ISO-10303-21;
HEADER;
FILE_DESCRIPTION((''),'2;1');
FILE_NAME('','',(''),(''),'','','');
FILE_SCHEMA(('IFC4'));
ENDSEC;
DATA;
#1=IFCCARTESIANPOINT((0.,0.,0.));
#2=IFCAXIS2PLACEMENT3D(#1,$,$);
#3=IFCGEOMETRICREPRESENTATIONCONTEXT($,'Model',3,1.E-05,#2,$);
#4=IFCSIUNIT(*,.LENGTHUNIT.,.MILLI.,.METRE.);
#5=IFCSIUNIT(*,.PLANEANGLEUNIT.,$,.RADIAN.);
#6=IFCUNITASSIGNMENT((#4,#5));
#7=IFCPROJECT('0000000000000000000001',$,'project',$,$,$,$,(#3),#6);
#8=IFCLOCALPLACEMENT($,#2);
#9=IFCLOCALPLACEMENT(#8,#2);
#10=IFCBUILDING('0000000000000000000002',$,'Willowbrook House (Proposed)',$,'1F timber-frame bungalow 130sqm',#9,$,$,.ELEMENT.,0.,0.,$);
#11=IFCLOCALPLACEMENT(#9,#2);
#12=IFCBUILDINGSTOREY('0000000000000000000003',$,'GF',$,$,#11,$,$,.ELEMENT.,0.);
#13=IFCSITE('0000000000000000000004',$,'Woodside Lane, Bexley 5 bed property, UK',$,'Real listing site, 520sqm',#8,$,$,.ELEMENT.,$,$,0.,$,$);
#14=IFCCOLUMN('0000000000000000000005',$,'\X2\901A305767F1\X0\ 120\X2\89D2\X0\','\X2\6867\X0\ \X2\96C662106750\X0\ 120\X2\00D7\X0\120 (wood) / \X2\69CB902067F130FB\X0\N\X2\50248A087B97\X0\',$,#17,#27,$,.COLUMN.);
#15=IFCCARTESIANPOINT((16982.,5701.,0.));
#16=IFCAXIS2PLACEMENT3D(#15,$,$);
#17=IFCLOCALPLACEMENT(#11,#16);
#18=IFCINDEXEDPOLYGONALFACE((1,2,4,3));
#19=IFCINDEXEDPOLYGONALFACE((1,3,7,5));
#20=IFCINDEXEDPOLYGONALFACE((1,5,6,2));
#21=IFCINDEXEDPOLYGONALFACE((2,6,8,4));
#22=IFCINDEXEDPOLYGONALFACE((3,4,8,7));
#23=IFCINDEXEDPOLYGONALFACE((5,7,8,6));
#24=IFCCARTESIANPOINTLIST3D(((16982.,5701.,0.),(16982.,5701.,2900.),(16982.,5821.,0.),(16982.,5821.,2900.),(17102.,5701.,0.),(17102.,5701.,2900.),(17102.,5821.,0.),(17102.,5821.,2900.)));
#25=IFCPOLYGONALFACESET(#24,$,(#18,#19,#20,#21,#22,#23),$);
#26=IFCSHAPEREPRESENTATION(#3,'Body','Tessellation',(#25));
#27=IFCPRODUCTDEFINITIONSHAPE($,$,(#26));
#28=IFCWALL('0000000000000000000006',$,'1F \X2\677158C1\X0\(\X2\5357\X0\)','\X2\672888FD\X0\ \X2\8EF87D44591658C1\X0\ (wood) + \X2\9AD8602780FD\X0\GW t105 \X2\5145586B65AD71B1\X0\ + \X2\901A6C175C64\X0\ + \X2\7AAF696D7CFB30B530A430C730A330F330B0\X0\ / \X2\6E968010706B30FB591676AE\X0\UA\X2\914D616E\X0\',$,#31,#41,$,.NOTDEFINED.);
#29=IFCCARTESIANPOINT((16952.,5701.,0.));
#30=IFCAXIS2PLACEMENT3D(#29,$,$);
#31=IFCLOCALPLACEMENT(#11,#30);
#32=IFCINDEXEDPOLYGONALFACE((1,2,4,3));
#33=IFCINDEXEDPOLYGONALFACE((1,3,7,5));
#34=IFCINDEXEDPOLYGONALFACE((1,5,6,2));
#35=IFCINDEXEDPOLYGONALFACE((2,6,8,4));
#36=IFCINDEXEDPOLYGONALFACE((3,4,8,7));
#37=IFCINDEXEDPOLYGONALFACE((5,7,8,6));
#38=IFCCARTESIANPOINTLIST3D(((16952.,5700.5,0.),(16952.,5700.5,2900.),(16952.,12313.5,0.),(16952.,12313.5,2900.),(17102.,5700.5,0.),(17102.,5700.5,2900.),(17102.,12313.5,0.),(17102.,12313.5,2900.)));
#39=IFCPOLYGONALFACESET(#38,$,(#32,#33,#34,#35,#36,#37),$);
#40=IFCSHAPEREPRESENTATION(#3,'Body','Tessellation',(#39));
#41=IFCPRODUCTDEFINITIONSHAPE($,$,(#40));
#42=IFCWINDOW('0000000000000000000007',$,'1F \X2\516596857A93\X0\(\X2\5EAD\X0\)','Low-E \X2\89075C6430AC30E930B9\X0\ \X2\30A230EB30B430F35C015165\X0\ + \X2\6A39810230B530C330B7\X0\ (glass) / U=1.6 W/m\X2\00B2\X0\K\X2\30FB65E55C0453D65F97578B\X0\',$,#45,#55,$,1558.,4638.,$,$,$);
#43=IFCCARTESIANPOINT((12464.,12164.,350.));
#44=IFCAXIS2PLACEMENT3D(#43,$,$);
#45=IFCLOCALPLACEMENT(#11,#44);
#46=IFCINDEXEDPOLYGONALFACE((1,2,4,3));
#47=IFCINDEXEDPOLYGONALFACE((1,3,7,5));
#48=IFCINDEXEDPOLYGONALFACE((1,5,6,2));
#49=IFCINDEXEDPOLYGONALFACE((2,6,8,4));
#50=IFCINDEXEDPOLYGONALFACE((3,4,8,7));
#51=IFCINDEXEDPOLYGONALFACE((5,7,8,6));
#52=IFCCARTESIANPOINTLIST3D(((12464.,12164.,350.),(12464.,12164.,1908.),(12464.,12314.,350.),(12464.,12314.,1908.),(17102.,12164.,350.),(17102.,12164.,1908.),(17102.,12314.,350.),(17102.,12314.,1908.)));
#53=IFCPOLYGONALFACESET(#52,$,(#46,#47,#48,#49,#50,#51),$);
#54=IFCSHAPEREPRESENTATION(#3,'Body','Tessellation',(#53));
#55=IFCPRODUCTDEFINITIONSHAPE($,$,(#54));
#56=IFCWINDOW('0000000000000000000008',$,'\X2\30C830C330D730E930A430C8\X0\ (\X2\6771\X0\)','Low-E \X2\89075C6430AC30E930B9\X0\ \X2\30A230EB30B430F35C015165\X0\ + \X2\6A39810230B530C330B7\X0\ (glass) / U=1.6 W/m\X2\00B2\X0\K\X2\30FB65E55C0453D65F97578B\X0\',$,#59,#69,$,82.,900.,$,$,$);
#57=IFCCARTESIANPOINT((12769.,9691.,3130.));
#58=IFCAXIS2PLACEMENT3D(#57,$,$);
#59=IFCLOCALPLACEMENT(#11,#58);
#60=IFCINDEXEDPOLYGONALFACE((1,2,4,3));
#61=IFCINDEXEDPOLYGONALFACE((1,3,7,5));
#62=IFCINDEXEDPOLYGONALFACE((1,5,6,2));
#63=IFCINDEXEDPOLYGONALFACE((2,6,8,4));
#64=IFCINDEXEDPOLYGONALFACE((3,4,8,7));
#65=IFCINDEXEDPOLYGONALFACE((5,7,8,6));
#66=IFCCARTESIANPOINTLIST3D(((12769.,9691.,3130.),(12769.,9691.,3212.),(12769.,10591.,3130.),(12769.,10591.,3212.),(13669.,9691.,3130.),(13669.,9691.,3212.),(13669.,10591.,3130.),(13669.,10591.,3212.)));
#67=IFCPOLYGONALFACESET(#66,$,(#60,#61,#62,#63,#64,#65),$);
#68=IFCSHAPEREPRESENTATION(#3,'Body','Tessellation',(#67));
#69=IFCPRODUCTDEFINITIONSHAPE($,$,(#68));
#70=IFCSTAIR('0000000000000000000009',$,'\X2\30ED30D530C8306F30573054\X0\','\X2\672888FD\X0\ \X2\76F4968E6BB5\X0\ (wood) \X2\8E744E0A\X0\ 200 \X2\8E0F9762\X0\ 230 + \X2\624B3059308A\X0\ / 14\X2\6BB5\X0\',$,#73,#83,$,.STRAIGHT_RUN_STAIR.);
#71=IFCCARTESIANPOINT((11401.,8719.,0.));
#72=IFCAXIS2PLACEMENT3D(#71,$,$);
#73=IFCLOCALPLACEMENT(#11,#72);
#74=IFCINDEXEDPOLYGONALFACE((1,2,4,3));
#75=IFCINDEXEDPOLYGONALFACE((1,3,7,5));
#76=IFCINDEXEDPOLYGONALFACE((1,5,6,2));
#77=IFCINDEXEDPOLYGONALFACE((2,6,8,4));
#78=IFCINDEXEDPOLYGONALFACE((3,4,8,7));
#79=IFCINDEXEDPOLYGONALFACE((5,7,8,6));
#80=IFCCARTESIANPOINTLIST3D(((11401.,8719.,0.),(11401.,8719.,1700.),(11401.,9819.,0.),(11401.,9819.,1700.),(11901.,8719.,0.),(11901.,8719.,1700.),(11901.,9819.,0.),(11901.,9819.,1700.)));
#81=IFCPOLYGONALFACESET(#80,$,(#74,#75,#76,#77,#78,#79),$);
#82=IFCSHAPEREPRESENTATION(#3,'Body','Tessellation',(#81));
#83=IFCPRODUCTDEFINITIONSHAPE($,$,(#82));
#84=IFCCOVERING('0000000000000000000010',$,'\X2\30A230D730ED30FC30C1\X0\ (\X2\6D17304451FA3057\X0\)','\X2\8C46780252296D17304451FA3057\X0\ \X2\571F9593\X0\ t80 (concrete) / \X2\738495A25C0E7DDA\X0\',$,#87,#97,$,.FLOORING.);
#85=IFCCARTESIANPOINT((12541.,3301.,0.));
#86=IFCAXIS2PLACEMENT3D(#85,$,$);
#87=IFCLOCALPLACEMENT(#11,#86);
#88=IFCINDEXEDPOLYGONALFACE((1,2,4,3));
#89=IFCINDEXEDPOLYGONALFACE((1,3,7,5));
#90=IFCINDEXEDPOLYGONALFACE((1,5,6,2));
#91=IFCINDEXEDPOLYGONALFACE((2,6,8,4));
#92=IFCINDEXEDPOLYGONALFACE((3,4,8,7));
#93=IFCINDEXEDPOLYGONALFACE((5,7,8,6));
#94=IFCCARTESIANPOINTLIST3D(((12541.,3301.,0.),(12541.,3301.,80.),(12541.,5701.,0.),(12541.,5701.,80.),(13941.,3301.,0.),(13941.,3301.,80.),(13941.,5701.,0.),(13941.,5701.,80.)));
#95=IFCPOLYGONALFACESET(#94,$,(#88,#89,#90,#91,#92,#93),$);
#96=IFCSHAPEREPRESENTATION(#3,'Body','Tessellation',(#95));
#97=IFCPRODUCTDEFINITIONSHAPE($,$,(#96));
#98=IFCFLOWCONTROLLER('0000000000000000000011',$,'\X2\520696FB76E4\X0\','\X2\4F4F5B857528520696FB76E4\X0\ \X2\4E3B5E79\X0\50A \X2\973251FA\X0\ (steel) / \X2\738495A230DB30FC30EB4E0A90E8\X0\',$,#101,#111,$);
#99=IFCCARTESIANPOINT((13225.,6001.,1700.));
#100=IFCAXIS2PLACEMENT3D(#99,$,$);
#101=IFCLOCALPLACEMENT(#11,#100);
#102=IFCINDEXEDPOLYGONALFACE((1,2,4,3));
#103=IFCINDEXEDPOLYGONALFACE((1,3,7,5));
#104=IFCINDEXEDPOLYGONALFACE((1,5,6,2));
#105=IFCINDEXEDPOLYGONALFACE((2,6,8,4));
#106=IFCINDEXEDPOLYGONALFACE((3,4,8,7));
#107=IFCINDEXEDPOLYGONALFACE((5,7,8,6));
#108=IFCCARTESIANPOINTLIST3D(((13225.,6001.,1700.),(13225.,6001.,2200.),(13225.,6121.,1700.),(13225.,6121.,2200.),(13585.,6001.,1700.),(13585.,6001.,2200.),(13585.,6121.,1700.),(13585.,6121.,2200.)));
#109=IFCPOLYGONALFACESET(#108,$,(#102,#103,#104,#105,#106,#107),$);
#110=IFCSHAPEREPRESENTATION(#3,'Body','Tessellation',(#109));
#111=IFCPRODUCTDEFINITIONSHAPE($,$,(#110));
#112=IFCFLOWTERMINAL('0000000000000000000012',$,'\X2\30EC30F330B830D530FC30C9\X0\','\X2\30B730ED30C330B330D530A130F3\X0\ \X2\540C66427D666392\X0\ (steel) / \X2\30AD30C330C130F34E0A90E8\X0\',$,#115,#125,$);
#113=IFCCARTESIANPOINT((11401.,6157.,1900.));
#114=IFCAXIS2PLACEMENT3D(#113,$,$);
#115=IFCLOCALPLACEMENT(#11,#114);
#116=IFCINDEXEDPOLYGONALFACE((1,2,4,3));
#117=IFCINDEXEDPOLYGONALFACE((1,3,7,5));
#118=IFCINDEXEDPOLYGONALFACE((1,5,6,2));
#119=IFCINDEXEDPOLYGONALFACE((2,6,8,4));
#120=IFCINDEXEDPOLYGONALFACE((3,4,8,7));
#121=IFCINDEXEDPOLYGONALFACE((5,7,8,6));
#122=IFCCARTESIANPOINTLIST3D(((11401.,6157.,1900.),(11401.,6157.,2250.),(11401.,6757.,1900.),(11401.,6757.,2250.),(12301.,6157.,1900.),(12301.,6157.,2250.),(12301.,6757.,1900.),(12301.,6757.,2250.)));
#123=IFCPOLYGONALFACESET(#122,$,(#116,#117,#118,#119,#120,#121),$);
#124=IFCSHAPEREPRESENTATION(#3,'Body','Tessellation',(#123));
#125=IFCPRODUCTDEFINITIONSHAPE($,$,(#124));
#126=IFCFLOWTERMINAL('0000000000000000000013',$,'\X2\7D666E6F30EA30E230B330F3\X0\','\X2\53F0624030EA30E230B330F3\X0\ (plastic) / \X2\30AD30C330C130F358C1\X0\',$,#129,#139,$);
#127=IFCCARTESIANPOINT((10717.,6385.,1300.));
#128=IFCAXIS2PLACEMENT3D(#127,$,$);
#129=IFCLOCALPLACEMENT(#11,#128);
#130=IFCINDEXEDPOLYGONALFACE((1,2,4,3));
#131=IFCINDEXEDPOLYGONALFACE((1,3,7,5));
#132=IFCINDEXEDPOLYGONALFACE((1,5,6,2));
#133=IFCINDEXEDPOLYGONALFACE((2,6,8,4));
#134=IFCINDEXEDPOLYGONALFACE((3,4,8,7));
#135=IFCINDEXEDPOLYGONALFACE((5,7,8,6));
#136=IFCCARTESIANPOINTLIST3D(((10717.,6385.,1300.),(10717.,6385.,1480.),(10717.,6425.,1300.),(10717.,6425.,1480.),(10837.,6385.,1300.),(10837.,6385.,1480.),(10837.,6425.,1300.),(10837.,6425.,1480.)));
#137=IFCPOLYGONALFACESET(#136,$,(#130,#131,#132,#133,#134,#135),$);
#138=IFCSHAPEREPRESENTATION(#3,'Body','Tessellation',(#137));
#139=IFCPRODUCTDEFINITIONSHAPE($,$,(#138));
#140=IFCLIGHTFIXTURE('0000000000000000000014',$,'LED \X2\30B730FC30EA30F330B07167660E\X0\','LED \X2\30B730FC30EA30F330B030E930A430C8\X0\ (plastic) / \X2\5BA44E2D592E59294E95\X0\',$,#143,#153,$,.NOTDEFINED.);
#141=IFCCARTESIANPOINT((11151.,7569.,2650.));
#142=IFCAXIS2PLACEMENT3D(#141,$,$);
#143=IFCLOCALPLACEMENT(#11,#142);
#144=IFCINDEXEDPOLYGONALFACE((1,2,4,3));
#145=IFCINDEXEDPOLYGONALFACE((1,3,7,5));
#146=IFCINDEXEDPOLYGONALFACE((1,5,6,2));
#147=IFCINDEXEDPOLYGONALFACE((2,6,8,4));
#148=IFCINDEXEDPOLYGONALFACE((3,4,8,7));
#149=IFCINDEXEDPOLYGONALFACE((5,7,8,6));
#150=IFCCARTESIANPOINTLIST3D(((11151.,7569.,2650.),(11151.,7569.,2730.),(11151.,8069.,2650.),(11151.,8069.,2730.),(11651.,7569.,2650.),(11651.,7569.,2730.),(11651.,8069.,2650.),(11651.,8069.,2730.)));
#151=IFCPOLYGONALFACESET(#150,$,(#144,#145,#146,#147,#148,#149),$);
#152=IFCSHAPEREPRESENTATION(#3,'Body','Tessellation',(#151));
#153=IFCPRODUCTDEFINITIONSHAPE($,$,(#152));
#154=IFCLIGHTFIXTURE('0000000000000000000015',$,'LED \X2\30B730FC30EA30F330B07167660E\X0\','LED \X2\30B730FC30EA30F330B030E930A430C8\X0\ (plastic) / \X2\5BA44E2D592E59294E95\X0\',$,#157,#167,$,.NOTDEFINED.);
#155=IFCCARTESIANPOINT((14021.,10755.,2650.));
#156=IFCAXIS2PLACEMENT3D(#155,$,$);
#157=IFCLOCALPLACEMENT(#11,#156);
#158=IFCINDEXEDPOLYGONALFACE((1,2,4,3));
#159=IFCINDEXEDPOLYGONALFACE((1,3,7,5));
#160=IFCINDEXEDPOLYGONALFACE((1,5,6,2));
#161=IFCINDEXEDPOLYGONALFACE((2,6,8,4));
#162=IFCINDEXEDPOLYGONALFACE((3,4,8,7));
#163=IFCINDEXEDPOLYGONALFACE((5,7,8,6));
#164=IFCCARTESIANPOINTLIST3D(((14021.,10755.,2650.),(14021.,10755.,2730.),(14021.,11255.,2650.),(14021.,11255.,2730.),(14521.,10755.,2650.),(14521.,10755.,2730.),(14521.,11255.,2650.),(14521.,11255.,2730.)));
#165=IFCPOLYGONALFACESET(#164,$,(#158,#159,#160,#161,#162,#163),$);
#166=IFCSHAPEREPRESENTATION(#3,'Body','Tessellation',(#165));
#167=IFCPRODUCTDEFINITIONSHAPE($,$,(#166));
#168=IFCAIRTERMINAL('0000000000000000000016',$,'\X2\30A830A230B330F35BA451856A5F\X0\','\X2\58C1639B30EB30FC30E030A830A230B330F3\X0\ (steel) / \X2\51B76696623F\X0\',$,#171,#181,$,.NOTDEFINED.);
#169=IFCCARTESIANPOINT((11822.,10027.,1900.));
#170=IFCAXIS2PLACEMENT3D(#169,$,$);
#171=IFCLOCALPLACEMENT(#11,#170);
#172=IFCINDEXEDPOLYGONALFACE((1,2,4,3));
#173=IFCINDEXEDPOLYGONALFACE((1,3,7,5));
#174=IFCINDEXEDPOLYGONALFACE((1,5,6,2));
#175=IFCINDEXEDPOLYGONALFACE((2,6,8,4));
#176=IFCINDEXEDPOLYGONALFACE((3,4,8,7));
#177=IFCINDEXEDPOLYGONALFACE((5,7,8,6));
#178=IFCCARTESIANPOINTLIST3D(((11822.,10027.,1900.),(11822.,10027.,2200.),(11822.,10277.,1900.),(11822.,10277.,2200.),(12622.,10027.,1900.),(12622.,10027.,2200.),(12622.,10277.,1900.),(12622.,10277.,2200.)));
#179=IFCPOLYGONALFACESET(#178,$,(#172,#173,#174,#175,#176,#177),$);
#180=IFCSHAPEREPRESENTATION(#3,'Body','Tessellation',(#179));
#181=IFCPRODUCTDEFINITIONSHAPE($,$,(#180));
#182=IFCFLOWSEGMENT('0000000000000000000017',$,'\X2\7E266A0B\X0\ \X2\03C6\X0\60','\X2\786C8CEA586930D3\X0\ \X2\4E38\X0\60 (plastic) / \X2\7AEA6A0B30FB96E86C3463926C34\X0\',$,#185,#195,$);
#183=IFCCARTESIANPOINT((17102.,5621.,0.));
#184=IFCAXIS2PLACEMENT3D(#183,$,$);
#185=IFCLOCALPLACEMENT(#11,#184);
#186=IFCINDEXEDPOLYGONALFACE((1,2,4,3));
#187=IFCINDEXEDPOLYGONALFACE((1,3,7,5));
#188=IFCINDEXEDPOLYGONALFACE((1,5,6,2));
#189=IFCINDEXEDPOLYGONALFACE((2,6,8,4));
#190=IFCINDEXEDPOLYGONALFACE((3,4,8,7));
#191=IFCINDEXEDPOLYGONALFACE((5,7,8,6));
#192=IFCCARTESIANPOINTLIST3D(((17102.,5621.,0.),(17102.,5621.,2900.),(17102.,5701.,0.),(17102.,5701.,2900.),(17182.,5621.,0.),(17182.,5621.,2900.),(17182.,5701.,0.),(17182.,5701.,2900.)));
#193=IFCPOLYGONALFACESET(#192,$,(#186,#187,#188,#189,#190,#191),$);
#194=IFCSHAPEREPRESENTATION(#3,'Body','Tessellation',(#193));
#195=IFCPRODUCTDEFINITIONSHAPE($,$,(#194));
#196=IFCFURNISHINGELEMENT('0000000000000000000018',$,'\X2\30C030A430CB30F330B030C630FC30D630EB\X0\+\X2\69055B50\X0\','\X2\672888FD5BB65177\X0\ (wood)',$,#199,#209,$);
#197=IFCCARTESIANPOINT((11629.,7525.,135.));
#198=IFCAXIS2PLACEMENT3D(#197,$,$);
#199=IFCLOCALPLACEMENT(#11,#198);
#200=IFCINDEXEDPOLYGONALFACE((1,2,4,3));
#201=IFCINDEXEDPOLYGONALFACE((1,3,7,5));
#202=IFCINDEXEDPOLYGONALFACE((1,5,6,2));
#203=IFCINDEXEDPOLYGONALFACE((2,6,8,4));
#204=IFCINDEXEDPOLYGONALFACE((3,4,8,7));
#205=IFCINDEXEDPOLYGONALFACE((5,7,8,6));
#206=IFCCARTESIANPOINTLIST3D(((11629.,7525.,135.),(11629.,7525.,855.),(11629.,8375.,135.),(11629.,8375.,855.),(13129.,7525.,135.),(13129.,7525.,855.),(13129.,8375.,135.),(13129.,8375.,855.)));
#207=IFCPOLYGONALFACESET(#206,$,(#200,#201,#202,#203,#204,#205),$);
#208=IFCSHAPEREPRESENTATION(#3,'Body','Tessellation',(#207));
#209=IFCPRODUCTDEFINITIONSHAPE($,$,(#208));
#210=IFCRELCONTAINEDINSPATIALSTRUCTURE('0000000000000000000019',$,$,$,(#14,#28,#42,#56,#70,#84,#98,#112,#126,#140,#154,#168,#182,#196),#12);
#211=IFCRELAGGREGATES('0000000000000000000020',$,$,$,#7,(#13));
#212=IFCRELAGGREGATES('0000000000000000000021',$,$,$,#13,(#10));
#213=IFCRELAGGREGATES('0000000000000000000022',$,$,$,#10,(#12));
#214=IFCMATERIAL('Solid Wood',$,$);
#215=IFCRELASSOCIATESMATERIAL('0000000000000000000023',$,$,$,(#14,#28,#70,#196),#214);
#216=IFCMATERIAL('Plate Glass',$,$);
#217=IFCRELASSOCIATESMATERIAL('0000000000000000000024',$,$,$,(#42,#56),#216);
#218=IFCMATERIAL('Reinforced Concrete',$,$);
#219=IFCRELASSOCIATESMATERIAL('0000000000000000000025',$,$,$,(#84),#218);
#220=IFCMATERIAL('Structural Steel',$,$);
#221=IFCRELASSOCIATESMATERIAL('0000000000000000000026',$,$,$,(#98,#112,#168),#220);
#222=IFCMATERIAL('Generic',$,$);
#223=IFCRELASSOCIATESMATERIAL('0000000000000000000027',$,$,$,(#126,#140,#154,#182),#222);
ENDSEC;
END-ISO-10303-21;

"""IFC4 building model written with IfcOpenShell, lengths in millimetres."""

from ifc_helpers import new_model, si_unit, frame, frame_2d, origin, place, context, project, spatial, rectangle, extrude, material, element, fill, save


model = new_model("IFC4")

# Units and contexts
model_context = context("Model", 3, precision=1e-05, world=origin())
ifc_project = project(units=[si_unit("LENGTHUNIT", "METRE", prefix="MILLI"), si_unit("PLANEANGLEUNIT", "RADIAN")], contexts=[model_context])

# Site, building, storey
site_placement = place(None, origin())
site = spatial("IfcSite", under=ifc_project, at=site_placement, Name="Woodside Lane, Bexley 5 bed property, UK", ObjectType="Real listing site, 520sqm", CompositionType="ELEMENT", RefElevation=0.0)
building_placement = place(site_placement, origin())
building = spatial("IfcBuilding", under=site, at=building_placement, Name="Willowbrook House (Proposed)", ObjectType="1F timber-frame bungalow 130sqm", CompositionType="ELEMENT", ElevationOfRefHeight=0.0, ElevationOfTerrain=0.0)
storey_placement = place(building_placement, origin())
storey = spatial("IfcBuildingStorey", under=building, at=storey_placement, Name="GF", CompositionType="ELEMENT", Elevation=0.0)

# Column
ifc_material_1 = material(Name="Solid Wood")
column_1_placement = place(storey_placement, frame((16982.0, 5701.0, 0.0)))
element("IfcColumn", 1, at=column_1_placement, inside=storey, material=ifc_material_1, Name="通し柱 120角", Description="桧 集成材 120×120 (wood) / 構造柱・N値計算", PredefinedType="COLUMN", context=model_context, shape_type="SweptSolid", body=[
    extrude(rectangle(XDim=120.0, YDim=120.0, at=frame_2d((60.0, 60.0))), frame((16982.0, 5701.0, 0.0)), (0.0, 0.0, 1.0), 2900.0),
])

# Wall, opening, window
wall_1_placement = place(storey_placement, frame((16952.0, 5701.0, 0.0)))
wall_1 = element("IfcWall", 2, at=wall_1_placement, inside=storey, material=ifc_material_1, Name="1F 東壁(南)", Description="木製 軸組外壁 (wood) + 高性能GW t105 充填断熱 + 通気層 + 窯業系サイディング / 準耐火・外皮UA配慮", PredefinedType="NOTDEFINED", context=model_context, shape_type="SweptSolid", body=[
    extrude(rectangle(XDim=150.0, YDim=6613.0, at=frame_2d((75.0, 3306.0))), frame((16952.0, 5701.0, 0.0)), (0.0, 0.0, 1.0), 2900.0),
])
opening_1_placement = place(storey_placement, frame((12464.0, 12164.0, 350.0)))
opening_1 = element("IfcOpeningElement", 3, at=opening_1_placement, cuts=wall_1, PredefinedType="NOTDEFINED", context=model_context, shape_type="SweptSolid", body=[
    extrude(rectangle(XDim=4638.0, YDim=150.0, at=frame_2d((2319.0, 75.0))), frame((12464.0, 12164.0, 350.0)), (0.0, 0.0, 1.0), 1558.0),
])
ifc_material_2 = material(Name="Plate Glass")
window_1_placement = place(storey_placement, frame((12464.0, 12164.0, 350.0)))
window_1 = element("IfcWindow", 4, at=window_1_placement, inside=storey, material=ifc_material_2, Name="1F 入隅窓(庭)", Description="Low-E 複層ガラス アルゴン封入 + 樹脂サッシ (glass) / U=1.6 W/m²K・日射取得型", OverallHeight=1558.0, OverallWidth=4638.0, context=model_context, shape_type="SweptSolid", body=[
    extrude(rectangle(XDim=4638.0, YDim=150.0, at=frame_2d((2319.0, 75.0))), frame((12464.0, 12164.0, 350.0)), (0.0, 0.0, 1.0), 1558.0),
])
fill(opening_1, window_1)

# Window
window_2_placement = place(storey_placement, frame((12769.0, 9691.0, 3130.0)))
element("IfcWindow", 5, at=window_2_placement, inside=storey, material=ifc_material_2, Name="トップライト (東)", Description="Low-E 複層ガラス アルゴン封入 + 樹脂サッシ (glass) / U=1.6 W/m²K・日射取得型", OverallHeight=82.0, OverallWidth=900.0, context=model_context, shape_type="SweptSolid", body=[
    extrude(rectangle(XDim=900.0, YDim=900.0, at=frame_2d((450.0, 450.0))), frame((12769.0, 9691.0, 3130.0)), (0.0, 0.0, 1.0), 82.0),
])

# Stair
stair_placement = place(storey_placement, frame((11401.0, 8719.0, 0.0)))
element("IfcStair", 6, at=stair_placement, inside=storey, material=ifc_material_1, Name="ロフトはしご", Description="木製 直階段 (wood) 蹴上 200 踏面 230 + 手すり / 14段", PredefinedType="STRAIGHT_RUN_STAIR", context=model_context, shape_type="SweptSolid", body=[
    extrude(rectangle(XDim=500.0, YDim=1100.0, at=frame_2d((250.0, 550.0))), frame((11401.0, 8719.0, 0.0)), (0.0, 0.0, 1.0), 1700.0),
])

# Covering
ifc_material_3 = material(Name="Reinforced Concrete")
covering_placement = place(storey_placement, frame((12541.0, 3301.0, 0.0)))
element("IfcCovering", 7, at=covering_placement, inside=storey, material=ifc_material_3, Name="アプローチ (洗い出し)", Description="豆砂利洗い出し 土間 t80 (concrete) / 玄関導線", PredefinedType="FLOORING", context=model_context, shape_type="SweptSolid", body=[
    extrude(rectangle(XDim=1400.0, YDim=2400.0, at=frame_2d((700.0, 1200.0))), frame((12541.0, 3301.0, 0.0)), (0.0, 0.0, 1.0), 80.0),
])

# Flow controller
ifc_material_4 = material(Name="Structural Steel")
flow_controller_placement = place(storey_placement, frame((13225.0, 6001.0, 1700.0)))
element("IfcFlowController", 8, at=flow_controller_placement, inside=storey, material=ifc_material_4, Name="分電盤", Description="住宅用分電盤 主幹50A 露出 (steel) / 玄関ホール上部", context=model_context, shape_type="SweptSolid", body=[
    extrude(rectangle(XDim=360.0, YDim=120.0, at=frame_2d((180.0, 60.0))), frame((13225.0, 6001.0, 1700.0)), (0.0, 0.0, 1.0), 500.0),
])

# Flow terminals
flow_terminal_1_placement = place(storey_placement, frame((11401.0, 6157.0, 1900.0)))
element("IfcFlowTerminal", 9, at=flow_terminal_1_placement, inside=storey, material=ifc_material_4, Name="レンジフード", Description="シロッコファン 同時給排 (steel) / キッチン上部", context=model_context, shape_type="SweptSolid", body=[
    extrude(rectangle(XDim=900.0, YDim=600.0, at=frame_2d((450.0, 300.0))), frame((11401.0, 6157.0, 1900.0)), (0.0, 0.0, 1.0), 350.0),
])
ifc_material_5 = material(Name="Generic")
flow_terminal_2_placement = place(storey_placement, frame((10717.0, 6385.0, 1300.0)))
element("IfcFlowTerminal", 10, at=flow_terminal_2_placement, inside=storey, material=ifc_material_5, Name="給湯リモコン", Description="台所リモコン (plastic) / キッチン壁", context=model_context, shape_type="SweptSolid", body=[
    extrude(rectangle(XDim=120.0, YDim=40.0, at=frame_2d((60.0, 20.0))), frame((10717.0, 6385.0, 1300.0)), (0.0, 0.0, 1.0), 180.0),
])

# Light fixtures
light_fixture_1_placement = place(storey_placement, frame((11151.0, 7569.0, 2650.0)))
element("IfcLightFixture", 11, at=light_fixture_1_placement, inside=storey, material=ifc_material_5, Name="LED シーリング照明", Description="LED シーリングライト (plastic) / 室中央天井", PredefinedType="NOTDEFINED", context=model_context, shape_type="SweptSolid", body=[
    extrude(rectangle(XDim=500.0, YDim=500.0, at=frame_2d((250.0, 250.0))), frame((11151.0, 7569.0, 2650.0)), (0.0, 0.0, 1.0), 80.0),
])
light_fixture_2_placement = place(storey_placement, frame((14021.0, 10755.0, 2650.0)))
element("IfcLightFixture", 12, at=light_fixture_2_placement, inside=storey, material=ifc_material_5, Name="LED シーリング照明", Description="LED シーリングライト (plastic) / 室中央天井", PredefinedType="NOTDEFINED", context=model_context, shape_type="SweptSolid", body=[
    extrude(rectangle(XDim=500.0, YDim=500.0, at=frame_2d((250.0, 250.0))), frame((14021.0, 10755.0, 2650.0)), (0.0, 0.0, 1.0), 80.0),
])

# Air terminal
air_terminal_placement = place(storey_placement, frame((11822.0, 10027.0, 1900.0)))
element("IfcAirTerminal", 13, at=air_terminal_placement, inside=storey, material=ifc_material_4, Name="エアコン室内機", Description="壁掛ルームエアコン (steel) / 冷暖房", PredefinedType="NOTDEFINED", context=model_context, shape_type="SweptSolid", body=[
    extrude(rectangle(XDim=800.0, YDim=250.0, at=frame_2d((400.0, 125.0))), frame((11822.0, 10027.0, 1900.0)), (0.0, 0.0, 1.0), 300.0),
])

# Flow segment
flow_segment_placement = place(storey_placement, frame((17102.0, 5621.0, 0.0)))
element("IfcFlowSegment", 14, at=flow_segment_placement, inside=storey, material=ifc_material_5, Name="縦樋 φ60", Description="硬質塩ビ 丸60 (plastic) / 竪樋・雨水排水", context=model_context, shape_type="SweptSolid", body=[
    extrude(rectangle(XDim=80.0, YDim=80.0, at=frame_2d((40.0, 40.0))), frame((17102.0, 5621.0, 0.0)), (0.0, 0.0, 1.0), 2900.0),
])

# Furnishing element
furnishing_1_placement = place(storey_placement, frame((11629.0, 7525.0, 135.0)))
element("IfcFurnishingElement", 15, at=furnishing_1_placement, inside=storey, material=ifc_material_1, Name="ダイニングテーブル+椅子", Description="木製家具 (wood)", context=model_context, shape_type="SweptSolid", body=[
    extrude(rectangle(XDim=1500.0, YDim=850.0, at=frame_2d((750.0, 425.0))), frame((11629.0, 7525.0, 135.0)), (0.0, 0.0, 1.0), 720.0),
])

save(model, "model.ifc")
